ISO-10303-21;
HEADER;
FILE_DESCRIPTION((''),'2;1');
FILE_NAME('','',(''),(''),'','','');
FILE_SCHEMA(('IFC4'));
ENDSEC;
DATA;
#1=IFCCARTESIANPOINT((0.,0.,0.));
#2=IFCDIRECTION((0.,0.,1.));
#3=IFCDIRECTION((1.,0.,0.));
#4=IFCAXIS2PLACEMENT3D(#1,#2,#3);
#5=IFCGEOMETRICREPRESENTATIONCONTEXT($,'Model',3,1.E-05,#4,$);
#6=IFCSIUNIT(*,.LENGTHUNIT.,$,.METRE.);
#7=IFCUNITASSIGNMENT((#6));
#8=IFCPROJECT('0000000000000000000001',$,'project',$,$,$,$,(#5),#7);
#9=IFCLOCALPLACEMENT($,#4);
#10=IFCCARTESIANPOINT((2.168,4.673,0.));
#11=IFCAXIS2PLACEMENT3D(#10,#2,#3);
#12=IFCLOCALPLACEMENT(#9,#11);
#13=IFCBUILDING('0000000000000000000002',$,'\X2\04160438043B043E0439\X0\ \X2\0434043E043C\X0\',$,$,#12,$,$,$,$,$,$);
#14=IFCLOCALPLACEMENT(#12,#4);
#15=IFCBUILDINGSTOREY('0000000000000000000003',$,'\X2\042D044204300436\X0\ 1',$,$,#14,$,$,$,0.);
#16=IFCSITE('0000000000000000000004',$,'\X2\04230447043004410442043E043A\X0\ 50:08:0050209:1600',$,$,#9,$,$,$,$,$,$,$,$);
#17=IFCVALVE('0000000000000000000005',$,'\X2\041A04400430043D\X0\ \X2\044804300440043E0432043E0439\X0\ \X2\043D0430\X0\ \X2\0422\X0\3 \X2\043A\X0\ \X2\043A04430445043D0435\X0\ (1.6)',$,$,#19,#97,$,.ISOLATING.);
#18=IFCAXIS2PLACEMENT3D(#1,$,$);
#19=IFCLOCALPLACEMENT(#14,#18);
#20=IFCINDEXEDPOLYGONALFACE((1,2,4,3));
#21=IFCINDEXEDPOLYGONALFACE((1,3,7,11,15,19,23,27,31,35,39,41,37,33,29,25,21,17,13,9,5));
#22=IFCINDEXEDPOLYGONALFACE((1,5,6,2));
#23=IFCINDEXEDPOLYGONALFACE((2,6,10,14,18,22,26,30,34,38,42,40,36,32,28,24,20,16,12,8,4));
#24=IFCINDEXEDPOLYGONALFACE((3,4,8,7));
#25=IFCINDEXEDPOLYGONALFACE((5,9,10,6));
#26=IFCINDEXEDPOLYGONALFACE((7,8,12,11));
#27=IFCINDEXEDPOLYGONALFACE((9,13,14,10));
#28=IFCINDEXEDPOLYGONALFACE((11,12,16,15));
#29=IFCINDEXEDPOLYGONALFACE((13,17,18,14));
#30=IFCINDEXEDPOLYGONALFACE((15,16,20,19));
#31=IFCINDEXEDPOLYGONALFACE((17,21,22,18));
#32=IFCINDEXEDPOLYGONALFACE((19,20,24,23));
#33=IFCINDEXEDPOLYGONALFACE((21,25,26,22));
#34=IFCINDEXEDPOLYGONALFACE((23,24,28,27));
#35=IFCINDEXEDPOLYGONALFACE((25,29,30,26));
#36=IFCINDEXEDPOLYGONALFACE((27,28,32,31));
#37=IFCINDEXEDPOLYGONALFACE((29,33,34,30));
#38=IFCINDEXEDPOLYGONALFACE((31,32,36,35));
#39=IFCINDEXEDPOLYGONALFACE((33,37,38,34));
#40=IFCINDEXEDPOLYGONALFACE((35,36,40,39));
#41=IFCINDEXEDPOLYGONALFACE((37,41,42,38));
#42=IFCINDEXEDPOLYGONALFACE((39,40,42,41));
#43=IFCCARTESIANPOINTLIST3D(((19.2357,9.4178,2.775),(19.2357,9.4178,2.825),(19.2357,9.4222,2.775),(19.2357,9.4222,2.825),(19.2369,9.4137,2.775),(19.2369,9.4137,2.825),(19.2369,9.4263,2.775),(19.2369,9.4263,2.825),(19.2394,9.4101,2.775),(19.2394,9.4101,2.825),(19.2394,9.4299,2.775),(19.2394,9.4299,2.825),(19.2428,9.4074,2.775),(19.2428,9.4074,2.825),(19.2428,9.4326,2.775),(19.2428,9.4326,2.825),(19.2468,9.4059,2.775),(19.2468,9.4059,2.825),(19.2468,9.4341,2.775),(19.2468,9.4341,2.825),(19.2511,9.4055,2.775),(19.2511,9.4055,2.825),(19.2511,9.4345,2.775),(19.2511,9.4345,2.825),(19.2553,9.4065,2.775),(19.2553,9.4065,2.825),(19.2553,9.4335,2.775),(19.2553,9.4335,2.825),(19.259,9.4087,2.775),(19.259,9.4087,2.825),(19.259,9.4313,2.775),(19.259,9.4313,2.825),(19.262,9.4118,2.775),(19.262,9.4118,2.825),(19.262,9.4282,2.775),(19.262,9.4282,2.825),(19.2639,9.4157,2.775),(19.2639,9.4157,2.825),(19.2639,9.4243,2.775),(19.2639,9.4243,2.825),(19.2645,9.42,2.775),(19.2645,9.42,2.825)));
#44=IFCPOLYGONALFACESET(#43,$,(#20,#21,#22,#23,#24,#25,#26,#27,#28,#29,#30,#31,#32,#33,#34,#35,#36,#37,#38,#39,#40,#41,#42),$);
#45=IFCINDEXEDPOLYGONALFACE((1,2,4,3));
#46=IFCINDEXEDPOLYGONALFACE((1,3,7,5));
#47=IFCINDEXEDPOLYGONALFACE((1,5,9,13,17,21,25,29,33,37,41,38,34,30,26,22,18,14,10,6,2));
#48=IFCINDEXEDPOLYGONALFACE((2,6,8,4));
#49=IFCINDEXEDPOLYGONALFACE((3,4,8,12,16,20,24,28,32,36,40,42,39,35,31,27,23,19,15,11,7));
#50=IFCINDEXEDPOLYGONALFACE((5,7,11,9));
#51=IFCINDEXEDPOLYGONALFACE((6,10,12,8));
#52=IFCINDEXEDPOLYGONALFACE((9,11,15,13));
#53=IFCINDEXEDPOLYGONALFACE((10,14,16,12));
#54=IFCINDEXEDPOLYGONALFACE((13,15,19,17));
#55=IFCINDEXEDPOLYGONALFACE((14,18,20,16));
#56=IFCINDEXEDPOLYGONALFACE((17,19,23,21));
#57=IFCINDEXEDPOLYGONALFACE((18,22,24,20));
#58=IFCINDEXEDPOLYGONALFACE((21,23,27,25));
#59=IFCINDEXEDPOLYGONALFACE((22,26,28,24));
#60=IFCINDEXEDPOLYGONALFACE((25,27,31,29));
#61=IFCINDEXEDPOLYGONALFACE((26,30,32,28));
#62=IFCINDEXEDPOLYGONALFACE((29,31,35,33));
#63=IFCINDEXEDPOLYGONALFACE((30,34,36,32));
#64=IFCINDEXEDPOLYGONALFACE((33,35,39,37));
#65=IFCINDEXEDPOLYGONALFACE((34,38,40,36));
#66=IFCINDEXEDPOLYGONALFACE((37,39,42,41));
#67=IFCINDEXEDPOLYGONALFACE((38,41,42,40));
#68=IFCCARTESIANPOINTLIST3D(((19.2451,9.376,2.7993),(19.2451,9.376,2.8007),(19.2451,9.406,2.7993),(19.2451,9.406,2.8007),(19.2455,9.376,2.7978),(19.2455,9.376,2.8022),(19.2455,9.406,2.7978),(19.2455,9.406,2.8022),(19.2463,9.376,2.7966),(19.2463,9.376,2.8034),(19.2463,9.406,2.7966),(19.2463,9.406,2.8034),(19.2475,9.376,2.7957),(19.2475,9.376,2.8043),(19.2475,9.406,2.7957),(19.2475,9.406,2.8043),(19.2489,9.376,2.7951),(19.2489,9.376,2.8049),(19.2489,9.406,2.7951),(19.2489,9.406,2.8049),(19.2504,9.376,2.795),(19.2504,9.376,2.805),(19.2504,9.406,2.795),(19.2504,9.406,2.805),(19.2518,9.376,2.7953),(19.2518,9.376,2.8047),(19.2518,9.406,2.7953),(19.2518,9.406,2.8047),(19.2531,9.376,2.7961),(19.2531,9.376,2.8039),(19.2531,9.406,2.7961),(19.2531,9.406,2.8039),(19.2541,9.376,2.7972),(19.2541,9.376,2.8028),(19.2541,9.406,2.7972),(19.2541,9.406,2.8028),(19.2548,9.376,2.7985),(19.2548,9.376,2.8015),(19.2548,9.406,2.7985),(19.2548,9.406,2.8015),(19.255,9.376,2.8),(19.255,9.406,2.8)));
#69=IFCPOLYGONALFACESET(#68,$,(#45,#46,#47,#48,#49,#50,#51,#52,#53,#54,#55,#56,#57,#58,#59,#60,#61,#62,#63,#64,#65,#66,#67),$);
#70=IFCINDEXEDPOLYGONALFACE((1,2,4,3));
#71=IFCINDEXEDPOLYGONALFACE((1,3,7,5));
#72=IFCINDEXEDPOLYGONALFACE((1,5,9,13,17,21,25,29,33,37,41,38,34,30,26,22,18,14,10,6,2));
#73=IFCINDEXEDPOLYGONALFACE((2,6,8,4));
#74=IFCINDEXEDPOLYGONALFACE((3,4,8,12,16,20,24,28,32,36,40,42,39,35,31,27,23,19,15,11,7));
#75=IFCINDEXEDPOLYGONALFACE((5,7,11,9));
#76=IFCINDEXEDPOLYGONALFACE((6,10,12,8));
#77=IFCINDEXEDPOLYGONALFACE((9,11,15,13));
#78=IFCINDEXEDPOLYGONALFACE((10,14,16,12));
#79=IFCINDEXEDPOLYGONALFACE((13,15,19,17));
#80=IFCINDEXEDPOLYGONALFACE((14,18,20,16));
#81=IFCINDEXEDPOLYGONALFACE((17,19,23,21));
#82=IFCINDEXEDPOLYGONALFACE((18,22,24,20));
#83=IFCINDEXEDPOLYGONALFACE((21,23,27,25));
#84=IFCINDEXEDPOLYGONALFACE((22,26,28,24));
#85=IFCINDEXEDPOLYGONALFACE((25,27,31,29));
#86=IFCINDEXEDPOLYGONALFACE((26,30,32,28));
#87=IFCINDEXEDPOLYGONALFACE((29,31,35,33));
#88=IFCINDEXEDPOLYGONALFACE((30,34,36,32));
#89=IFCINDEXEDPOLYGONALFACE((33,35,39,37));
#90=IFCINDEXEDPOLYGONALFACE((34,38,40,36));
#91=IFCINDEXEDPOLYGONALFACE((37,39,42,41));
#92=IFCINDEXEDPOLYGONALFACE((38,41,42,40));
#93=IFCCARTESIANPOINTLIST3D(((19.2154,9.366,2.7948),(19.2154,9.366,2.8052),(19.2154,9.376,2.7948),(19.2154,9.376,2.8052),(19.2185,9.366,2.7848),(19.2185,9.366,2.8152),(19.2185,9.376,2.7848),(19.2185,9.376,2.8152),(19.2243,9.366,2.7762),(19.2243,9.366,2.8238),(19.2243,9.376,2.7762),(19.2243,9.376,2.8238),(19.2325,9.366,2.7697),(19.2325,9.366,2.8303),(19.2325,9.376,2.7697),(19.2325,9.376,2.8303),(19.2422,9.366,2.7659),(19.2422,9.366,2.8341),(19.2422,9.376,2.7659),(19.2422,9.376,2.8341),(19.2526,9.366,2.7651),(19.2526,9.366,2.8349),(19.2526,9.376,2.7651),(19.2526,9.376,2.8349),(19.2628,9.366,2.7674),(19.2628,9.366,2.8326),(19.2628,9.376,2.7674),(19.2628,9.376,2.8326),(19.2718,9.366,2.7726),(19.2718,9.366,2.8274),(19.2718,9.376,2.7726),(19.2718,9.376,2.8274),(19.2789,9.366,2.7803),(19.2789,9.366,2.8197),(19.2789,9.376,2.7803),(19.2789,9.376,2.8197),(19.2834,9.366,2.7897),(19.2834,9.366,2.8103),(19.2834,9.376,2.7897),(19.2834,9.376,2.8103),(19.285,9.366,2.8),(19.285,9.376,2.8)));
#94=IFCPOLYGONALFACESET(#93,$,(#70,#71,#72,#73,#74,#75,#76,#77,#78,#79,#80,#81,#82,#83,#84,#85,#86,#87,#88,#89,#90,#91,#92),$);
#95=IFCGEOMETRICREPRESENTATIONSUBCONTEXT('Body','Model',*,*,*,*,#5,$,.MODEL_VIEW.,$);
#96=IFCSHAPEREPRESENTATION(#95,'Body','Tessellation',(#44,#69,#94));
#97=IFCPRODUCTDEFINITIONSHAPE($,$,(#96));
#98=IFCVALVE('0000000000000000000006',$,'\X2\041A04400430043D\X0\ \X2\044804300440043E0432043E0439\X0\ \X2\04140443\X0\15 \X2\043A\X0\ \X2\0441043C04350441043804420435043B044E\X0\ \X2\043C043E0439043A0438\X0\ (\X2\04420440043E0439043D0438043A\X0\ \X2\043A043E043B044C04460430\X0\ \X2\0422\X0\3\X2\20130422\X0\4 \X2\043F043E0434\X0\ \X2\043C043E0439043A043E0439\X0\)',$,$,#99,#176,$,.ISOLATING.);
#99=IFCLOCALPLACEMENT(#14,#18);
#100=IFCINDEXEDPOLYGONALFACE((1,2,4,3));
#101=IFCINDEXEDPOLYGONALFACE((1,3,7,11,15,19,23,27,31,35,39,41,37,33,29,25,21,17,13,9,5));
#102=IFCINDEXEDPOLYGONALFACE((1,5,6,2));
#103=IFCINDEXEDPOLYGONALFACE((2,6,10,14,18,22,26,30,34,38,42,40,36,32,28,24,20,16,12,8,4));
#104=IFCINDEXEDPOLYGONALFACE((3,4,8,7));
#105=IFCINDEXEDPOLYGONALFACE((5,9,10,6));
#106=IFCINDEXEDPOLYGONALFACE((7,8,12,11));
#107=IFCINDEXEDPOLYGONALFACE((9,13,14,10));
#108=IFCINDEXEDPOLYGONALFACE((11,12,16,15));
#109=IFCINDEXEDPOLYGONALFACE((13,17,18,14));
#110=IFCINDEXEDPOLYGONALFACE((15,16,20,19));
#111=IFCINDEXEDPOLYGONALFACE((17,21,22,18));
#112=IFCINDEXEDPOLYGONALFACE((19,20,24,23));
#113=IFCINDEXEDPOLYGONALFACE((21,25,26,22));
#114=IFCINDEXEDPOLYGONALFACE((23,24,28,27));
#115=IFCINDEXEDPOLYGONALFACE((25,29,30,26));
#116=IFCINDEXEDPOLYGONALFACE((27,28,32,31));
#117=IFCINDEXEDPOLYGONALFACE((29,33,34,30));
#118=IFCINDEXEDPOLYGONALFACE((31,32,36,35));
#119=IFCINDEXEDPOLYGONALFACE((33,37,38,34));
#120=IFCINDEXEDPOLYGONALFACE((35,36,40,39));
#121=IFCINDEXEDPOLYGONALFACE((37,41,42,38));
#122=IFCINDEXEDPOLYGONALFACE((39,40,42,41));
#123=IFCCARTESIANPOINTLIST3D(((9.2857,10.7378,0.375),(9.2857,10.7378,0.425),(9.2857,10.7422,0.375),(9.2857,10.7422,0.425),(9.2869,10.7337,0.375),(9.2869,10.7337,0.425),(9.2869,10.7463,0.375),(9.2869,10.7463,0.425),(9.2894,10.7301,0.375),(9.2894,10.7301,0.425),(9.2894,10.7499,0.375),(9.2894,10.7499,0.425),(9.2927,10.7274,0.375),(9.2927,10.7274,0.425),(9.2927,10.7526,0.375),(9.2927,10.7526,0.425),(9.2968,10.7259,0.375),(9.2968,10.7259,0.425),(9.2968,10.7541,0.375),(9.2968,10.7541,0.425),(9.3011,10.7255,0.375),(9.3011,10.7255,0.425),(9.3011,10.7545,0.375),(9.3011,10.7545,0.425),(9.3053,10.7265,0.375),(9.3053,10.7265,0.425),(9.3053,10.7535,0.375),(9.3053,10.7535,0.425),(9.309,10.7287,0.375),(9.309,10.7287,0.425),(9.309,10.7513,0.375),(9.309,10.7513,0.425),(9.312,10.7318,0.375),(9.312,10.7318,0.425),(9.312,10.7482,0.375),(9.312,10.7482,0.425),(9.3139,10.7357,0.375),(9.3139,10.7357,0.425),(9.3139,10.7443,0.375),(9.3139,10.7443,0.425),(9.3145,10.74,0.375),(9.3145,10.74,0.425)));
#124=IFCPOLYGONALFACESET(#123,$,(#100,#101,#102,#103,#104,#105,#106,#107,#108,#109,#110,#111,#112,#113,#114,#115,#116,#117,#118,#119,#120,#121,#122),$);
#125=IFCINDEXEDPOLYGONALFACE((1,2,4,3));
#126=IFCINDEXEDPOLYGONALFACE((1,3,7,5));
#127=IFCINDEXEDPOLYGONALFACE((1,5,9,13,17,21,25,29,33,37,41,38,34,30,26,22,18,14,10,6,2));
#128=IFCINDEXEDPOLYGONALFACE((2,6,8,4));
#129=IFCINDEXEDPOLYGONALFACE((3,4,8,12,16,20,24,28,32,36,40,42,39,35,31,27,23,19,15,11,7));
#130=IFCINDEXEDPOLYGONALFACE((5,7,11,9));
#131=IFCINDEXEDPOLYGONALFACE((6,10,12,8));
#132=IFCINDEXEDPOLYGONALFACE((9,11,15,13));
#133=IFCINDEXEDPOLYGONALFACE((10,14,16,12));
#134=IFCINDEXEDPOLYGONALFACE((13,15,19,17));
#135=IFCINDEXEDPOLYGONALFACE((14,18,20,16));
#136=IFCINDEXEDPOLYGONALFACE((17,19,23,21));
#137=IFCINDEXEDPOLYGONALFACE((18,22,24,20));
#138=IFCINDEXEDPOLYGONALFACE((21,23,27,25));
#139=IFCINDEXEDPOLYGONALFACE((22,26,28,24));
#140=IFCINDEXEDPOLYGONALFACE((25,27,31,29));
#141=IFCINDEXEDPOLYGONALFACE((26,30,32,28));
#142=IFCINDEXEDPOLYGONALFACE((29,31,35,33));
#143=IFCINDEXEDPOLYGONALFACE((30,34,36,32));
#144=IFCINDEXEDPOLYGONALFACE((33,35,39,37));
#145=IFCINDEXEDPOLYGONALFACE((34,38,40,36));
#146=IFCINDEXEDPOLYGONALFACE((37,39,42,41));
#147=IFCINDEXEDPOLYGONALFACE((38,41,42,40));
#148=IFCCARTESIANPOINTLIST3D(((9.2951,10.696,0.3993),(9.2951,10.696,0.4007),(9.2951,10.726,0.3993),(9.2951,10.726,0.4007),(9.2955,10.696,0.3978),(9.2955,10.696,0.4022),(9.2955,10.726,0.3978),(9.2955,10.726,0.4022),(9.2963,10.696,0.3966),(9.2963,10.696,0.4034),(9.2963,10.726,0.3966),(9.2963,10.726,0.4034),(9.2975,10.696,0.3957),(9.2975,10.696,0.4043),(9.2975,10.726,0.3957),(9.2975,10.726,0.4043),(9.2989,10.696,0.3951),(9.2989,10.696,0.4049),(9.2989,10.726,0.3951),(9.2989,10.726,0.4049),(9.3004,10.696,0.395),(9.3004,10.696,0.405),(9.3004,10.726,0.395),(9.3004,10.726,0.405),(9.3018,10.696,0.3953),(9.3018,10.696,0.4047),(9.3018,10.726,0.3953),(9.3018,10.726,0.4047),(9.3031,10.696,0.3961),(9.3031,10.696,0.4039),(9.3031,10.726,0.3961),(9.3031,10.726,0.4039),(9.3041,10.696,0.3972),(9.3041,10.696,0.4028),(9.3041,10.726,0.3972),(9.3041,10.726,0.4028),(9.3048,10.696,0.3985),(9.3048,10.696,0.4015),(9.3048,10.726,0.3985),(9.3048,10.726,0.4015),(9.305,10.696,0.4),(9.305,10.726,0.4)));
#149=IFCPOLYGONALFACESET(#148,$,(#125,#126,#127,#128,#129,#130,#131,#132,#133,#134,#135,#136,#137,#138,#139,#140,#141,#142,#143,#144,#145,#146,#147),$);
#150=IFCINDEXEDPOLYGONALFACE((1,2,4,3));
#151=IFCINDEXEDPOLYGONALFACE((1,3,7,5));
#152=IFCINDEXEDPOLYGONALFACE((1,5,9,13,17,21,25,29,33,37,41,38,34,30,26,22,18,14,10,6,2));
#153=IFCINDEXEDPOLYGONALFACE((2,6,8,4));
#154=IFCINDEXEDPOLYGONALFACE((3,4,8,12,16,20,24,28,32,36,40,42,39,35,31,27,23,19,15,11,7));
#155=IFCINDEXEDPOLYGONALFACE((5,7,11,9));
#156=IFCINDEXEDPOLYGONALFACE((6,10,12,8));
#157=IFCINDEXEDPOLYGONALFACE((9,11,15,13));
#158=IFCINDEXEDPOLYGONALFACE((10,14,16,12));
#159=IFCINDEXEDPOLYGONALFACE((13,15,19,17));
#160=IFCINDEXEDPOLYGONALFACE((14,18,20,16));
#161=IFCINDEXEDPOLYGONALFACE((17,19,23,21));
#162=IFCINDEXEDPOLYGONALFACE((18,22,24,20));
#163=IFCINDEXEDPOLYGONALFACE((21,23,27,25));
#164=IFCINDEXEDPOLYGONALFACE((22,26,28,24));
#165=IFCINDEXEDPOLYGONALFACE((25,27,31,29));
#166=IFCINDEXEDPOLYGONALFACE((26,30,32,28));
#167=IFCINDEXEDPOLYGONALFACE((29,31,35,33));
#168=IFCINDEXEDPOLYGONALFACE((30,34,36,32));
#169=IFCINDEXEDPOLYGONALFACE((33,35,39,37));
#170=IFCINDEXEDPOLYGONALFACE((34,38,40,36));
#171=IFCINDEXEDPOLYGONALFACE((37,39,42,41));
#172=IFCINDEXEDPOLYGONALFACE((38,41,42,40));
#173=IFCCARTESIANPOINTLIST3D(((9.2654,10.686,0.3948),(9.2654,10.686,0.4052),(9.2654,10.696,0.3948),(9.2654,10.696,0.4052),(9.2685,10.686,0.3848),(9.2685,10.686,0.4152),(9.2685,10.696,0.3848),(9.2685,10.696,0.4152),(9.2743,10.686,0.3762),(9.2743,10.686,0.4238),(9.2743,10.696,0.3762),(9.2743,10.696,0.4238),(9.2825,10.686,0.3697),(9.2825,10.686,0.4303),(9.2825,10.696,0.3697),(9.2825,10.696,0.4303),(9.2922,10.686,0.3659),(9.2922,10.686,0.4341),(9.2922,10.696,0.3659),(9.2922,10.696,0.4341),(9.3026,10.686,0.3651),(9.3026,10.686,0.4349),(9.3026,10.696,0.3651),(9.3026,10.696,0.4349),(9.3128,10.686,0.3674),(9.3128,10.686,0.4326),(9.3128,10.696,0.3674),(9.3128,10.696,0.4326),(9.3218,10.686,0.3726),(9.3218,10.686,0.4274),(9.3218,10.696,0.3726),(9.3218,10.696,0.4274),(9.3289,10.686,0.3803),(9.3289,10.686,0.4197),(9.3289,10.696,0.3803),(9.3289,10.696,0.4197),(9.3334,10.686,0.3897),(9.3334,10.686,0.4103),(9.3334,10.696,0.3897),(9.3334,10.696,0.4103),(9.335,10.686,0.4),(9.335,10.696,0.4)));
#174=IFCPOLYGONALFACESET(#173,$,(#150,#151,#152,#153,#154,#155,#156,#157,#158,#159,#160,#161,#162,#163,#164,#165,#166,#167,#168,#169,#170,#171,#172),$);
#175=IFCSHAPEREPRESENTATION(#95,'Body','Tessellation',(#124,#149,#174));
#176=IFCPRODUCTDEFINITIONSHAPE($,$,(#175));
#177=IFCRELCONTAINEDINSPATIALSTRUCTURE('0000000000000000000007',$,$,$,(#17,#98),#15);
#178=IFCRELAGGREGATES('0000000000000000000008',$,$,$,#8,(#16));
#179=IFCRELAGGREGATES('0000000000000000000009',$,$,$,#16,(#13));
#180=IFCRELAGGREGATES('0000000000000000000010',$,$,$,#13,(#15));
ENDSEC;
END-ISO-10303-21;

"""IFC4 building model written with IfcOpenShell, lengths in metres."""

from ifc_helpers import new_model, si_unit, frame, origin_with_axes, origin_2d, place, context, subcontext, project, spatial, circle, extrude, element, save


model = new_model("IFC4")

# Units and contexts
model_context = context("Model", 3, precision=1e-05, world=origin_with_axes())
body_context = subcontext(model_context, "Body", "Model", "MODEL_VIEW")
ifc_project = project(units=[si_unit("LENGTHUNIT", "METRE")], contexts=[model_context])

# Site, building, storey
site_placement = place(None, origin_with_axes())
site = spatial("IfcSite", under=ifc_project, at=site_placement, Name="Участок 50:08:0050209:1600")
building_placement = place(site_placement, frame((2.168, 4.673, 0.0), z_axis=(0.0, 0.0, 1.0), x_axis=(1.0, 0.0, 0.0)))
building = spatial("IfcBuilding", under=site, at=building_placement, Name="Жилой дом")
storey_placement = place(building_placement, origin_with_axes())
storey = spatial("IfcBuildingStorey", under=building, at=storey_placement, Name="Этаж 1", Elevation=0.0)

# Valves
valve_1_placement = place(storey_placement, origin_with_axes())
element("IfcValve", 1, at=valve_1_placement, inside=storey, Name="Кран шаровой на Т3 к кухне (1.6)", PredefinedType="ISOLATING", context=body_context, shape_type="SweptSolid", body=[
    extrude(circle(Radius=0.0145, at=origin_2d()), frame((19.25, 9.42, 2.775), z_axis=(0.0, 0.0, 1.0), x_axis=(1.0, 0.0, 0.0)), (0.0, 0.0, 1.0), 0.05),
    extrude(circle(Radius=0.005, at=origin_2d()), frame((19.25, 9.406, 2.8), z_axis=(0.0, -1.0, 0.0), x_axis=(1.0, 0.0, 0.0)), (0.0, 0.0, 1.0), 0.03),
    extrude(circle(Radius=0.035, at=origin_2d()), frame((19.25, 9.376, 2.8), z_axis=(0.0, -1.0, 0.0), x_axis=(1.0, 0.0, 0.0)), (0.0, 0.0, 1.0), 0.01),
])
valve_2_placement = place(storey_placement, origin_with_axes())
element("IfcValve", 2, at=valve_2_placement, inside=storey, Name="Кран шаровой Ду15 к смесителю мойки (тройник кольца Т3–Т4 под мойкой)", PredefinedType="ISOLATING", context=body_context, shape_type="SweptSolid", body=[
    extrude(circle(Radius=0.0145, at=origin_2d()), frame((9.3, 10.74, 0.375), z_axis=(0.0, 0.0, 1.0), x_axis=(1.0, 0.0, 0.0)), (0.0, 0.0, 1.0), 0.05),
    extrude(circle(Radius=0.005, at=origin_2d()), frame((9.3, 10.726, 0.4), z_axis=(0.0, -1.0, 0.0), x_axis=(1.0, 0.0, 0.0)), (0.0, 0.0, 1.0), 0.03),
    extrude(circle(Radius=0.035, at=origin_2d()), frame((9.3, 10.696, 0.4), z_axis=(0.0, -1.0, 0.0), x_axis=(1.0, 0.0, 0.0)), (0.0, 0.0, 1.0), 0.01),
])

save(model, "model.ifc")
